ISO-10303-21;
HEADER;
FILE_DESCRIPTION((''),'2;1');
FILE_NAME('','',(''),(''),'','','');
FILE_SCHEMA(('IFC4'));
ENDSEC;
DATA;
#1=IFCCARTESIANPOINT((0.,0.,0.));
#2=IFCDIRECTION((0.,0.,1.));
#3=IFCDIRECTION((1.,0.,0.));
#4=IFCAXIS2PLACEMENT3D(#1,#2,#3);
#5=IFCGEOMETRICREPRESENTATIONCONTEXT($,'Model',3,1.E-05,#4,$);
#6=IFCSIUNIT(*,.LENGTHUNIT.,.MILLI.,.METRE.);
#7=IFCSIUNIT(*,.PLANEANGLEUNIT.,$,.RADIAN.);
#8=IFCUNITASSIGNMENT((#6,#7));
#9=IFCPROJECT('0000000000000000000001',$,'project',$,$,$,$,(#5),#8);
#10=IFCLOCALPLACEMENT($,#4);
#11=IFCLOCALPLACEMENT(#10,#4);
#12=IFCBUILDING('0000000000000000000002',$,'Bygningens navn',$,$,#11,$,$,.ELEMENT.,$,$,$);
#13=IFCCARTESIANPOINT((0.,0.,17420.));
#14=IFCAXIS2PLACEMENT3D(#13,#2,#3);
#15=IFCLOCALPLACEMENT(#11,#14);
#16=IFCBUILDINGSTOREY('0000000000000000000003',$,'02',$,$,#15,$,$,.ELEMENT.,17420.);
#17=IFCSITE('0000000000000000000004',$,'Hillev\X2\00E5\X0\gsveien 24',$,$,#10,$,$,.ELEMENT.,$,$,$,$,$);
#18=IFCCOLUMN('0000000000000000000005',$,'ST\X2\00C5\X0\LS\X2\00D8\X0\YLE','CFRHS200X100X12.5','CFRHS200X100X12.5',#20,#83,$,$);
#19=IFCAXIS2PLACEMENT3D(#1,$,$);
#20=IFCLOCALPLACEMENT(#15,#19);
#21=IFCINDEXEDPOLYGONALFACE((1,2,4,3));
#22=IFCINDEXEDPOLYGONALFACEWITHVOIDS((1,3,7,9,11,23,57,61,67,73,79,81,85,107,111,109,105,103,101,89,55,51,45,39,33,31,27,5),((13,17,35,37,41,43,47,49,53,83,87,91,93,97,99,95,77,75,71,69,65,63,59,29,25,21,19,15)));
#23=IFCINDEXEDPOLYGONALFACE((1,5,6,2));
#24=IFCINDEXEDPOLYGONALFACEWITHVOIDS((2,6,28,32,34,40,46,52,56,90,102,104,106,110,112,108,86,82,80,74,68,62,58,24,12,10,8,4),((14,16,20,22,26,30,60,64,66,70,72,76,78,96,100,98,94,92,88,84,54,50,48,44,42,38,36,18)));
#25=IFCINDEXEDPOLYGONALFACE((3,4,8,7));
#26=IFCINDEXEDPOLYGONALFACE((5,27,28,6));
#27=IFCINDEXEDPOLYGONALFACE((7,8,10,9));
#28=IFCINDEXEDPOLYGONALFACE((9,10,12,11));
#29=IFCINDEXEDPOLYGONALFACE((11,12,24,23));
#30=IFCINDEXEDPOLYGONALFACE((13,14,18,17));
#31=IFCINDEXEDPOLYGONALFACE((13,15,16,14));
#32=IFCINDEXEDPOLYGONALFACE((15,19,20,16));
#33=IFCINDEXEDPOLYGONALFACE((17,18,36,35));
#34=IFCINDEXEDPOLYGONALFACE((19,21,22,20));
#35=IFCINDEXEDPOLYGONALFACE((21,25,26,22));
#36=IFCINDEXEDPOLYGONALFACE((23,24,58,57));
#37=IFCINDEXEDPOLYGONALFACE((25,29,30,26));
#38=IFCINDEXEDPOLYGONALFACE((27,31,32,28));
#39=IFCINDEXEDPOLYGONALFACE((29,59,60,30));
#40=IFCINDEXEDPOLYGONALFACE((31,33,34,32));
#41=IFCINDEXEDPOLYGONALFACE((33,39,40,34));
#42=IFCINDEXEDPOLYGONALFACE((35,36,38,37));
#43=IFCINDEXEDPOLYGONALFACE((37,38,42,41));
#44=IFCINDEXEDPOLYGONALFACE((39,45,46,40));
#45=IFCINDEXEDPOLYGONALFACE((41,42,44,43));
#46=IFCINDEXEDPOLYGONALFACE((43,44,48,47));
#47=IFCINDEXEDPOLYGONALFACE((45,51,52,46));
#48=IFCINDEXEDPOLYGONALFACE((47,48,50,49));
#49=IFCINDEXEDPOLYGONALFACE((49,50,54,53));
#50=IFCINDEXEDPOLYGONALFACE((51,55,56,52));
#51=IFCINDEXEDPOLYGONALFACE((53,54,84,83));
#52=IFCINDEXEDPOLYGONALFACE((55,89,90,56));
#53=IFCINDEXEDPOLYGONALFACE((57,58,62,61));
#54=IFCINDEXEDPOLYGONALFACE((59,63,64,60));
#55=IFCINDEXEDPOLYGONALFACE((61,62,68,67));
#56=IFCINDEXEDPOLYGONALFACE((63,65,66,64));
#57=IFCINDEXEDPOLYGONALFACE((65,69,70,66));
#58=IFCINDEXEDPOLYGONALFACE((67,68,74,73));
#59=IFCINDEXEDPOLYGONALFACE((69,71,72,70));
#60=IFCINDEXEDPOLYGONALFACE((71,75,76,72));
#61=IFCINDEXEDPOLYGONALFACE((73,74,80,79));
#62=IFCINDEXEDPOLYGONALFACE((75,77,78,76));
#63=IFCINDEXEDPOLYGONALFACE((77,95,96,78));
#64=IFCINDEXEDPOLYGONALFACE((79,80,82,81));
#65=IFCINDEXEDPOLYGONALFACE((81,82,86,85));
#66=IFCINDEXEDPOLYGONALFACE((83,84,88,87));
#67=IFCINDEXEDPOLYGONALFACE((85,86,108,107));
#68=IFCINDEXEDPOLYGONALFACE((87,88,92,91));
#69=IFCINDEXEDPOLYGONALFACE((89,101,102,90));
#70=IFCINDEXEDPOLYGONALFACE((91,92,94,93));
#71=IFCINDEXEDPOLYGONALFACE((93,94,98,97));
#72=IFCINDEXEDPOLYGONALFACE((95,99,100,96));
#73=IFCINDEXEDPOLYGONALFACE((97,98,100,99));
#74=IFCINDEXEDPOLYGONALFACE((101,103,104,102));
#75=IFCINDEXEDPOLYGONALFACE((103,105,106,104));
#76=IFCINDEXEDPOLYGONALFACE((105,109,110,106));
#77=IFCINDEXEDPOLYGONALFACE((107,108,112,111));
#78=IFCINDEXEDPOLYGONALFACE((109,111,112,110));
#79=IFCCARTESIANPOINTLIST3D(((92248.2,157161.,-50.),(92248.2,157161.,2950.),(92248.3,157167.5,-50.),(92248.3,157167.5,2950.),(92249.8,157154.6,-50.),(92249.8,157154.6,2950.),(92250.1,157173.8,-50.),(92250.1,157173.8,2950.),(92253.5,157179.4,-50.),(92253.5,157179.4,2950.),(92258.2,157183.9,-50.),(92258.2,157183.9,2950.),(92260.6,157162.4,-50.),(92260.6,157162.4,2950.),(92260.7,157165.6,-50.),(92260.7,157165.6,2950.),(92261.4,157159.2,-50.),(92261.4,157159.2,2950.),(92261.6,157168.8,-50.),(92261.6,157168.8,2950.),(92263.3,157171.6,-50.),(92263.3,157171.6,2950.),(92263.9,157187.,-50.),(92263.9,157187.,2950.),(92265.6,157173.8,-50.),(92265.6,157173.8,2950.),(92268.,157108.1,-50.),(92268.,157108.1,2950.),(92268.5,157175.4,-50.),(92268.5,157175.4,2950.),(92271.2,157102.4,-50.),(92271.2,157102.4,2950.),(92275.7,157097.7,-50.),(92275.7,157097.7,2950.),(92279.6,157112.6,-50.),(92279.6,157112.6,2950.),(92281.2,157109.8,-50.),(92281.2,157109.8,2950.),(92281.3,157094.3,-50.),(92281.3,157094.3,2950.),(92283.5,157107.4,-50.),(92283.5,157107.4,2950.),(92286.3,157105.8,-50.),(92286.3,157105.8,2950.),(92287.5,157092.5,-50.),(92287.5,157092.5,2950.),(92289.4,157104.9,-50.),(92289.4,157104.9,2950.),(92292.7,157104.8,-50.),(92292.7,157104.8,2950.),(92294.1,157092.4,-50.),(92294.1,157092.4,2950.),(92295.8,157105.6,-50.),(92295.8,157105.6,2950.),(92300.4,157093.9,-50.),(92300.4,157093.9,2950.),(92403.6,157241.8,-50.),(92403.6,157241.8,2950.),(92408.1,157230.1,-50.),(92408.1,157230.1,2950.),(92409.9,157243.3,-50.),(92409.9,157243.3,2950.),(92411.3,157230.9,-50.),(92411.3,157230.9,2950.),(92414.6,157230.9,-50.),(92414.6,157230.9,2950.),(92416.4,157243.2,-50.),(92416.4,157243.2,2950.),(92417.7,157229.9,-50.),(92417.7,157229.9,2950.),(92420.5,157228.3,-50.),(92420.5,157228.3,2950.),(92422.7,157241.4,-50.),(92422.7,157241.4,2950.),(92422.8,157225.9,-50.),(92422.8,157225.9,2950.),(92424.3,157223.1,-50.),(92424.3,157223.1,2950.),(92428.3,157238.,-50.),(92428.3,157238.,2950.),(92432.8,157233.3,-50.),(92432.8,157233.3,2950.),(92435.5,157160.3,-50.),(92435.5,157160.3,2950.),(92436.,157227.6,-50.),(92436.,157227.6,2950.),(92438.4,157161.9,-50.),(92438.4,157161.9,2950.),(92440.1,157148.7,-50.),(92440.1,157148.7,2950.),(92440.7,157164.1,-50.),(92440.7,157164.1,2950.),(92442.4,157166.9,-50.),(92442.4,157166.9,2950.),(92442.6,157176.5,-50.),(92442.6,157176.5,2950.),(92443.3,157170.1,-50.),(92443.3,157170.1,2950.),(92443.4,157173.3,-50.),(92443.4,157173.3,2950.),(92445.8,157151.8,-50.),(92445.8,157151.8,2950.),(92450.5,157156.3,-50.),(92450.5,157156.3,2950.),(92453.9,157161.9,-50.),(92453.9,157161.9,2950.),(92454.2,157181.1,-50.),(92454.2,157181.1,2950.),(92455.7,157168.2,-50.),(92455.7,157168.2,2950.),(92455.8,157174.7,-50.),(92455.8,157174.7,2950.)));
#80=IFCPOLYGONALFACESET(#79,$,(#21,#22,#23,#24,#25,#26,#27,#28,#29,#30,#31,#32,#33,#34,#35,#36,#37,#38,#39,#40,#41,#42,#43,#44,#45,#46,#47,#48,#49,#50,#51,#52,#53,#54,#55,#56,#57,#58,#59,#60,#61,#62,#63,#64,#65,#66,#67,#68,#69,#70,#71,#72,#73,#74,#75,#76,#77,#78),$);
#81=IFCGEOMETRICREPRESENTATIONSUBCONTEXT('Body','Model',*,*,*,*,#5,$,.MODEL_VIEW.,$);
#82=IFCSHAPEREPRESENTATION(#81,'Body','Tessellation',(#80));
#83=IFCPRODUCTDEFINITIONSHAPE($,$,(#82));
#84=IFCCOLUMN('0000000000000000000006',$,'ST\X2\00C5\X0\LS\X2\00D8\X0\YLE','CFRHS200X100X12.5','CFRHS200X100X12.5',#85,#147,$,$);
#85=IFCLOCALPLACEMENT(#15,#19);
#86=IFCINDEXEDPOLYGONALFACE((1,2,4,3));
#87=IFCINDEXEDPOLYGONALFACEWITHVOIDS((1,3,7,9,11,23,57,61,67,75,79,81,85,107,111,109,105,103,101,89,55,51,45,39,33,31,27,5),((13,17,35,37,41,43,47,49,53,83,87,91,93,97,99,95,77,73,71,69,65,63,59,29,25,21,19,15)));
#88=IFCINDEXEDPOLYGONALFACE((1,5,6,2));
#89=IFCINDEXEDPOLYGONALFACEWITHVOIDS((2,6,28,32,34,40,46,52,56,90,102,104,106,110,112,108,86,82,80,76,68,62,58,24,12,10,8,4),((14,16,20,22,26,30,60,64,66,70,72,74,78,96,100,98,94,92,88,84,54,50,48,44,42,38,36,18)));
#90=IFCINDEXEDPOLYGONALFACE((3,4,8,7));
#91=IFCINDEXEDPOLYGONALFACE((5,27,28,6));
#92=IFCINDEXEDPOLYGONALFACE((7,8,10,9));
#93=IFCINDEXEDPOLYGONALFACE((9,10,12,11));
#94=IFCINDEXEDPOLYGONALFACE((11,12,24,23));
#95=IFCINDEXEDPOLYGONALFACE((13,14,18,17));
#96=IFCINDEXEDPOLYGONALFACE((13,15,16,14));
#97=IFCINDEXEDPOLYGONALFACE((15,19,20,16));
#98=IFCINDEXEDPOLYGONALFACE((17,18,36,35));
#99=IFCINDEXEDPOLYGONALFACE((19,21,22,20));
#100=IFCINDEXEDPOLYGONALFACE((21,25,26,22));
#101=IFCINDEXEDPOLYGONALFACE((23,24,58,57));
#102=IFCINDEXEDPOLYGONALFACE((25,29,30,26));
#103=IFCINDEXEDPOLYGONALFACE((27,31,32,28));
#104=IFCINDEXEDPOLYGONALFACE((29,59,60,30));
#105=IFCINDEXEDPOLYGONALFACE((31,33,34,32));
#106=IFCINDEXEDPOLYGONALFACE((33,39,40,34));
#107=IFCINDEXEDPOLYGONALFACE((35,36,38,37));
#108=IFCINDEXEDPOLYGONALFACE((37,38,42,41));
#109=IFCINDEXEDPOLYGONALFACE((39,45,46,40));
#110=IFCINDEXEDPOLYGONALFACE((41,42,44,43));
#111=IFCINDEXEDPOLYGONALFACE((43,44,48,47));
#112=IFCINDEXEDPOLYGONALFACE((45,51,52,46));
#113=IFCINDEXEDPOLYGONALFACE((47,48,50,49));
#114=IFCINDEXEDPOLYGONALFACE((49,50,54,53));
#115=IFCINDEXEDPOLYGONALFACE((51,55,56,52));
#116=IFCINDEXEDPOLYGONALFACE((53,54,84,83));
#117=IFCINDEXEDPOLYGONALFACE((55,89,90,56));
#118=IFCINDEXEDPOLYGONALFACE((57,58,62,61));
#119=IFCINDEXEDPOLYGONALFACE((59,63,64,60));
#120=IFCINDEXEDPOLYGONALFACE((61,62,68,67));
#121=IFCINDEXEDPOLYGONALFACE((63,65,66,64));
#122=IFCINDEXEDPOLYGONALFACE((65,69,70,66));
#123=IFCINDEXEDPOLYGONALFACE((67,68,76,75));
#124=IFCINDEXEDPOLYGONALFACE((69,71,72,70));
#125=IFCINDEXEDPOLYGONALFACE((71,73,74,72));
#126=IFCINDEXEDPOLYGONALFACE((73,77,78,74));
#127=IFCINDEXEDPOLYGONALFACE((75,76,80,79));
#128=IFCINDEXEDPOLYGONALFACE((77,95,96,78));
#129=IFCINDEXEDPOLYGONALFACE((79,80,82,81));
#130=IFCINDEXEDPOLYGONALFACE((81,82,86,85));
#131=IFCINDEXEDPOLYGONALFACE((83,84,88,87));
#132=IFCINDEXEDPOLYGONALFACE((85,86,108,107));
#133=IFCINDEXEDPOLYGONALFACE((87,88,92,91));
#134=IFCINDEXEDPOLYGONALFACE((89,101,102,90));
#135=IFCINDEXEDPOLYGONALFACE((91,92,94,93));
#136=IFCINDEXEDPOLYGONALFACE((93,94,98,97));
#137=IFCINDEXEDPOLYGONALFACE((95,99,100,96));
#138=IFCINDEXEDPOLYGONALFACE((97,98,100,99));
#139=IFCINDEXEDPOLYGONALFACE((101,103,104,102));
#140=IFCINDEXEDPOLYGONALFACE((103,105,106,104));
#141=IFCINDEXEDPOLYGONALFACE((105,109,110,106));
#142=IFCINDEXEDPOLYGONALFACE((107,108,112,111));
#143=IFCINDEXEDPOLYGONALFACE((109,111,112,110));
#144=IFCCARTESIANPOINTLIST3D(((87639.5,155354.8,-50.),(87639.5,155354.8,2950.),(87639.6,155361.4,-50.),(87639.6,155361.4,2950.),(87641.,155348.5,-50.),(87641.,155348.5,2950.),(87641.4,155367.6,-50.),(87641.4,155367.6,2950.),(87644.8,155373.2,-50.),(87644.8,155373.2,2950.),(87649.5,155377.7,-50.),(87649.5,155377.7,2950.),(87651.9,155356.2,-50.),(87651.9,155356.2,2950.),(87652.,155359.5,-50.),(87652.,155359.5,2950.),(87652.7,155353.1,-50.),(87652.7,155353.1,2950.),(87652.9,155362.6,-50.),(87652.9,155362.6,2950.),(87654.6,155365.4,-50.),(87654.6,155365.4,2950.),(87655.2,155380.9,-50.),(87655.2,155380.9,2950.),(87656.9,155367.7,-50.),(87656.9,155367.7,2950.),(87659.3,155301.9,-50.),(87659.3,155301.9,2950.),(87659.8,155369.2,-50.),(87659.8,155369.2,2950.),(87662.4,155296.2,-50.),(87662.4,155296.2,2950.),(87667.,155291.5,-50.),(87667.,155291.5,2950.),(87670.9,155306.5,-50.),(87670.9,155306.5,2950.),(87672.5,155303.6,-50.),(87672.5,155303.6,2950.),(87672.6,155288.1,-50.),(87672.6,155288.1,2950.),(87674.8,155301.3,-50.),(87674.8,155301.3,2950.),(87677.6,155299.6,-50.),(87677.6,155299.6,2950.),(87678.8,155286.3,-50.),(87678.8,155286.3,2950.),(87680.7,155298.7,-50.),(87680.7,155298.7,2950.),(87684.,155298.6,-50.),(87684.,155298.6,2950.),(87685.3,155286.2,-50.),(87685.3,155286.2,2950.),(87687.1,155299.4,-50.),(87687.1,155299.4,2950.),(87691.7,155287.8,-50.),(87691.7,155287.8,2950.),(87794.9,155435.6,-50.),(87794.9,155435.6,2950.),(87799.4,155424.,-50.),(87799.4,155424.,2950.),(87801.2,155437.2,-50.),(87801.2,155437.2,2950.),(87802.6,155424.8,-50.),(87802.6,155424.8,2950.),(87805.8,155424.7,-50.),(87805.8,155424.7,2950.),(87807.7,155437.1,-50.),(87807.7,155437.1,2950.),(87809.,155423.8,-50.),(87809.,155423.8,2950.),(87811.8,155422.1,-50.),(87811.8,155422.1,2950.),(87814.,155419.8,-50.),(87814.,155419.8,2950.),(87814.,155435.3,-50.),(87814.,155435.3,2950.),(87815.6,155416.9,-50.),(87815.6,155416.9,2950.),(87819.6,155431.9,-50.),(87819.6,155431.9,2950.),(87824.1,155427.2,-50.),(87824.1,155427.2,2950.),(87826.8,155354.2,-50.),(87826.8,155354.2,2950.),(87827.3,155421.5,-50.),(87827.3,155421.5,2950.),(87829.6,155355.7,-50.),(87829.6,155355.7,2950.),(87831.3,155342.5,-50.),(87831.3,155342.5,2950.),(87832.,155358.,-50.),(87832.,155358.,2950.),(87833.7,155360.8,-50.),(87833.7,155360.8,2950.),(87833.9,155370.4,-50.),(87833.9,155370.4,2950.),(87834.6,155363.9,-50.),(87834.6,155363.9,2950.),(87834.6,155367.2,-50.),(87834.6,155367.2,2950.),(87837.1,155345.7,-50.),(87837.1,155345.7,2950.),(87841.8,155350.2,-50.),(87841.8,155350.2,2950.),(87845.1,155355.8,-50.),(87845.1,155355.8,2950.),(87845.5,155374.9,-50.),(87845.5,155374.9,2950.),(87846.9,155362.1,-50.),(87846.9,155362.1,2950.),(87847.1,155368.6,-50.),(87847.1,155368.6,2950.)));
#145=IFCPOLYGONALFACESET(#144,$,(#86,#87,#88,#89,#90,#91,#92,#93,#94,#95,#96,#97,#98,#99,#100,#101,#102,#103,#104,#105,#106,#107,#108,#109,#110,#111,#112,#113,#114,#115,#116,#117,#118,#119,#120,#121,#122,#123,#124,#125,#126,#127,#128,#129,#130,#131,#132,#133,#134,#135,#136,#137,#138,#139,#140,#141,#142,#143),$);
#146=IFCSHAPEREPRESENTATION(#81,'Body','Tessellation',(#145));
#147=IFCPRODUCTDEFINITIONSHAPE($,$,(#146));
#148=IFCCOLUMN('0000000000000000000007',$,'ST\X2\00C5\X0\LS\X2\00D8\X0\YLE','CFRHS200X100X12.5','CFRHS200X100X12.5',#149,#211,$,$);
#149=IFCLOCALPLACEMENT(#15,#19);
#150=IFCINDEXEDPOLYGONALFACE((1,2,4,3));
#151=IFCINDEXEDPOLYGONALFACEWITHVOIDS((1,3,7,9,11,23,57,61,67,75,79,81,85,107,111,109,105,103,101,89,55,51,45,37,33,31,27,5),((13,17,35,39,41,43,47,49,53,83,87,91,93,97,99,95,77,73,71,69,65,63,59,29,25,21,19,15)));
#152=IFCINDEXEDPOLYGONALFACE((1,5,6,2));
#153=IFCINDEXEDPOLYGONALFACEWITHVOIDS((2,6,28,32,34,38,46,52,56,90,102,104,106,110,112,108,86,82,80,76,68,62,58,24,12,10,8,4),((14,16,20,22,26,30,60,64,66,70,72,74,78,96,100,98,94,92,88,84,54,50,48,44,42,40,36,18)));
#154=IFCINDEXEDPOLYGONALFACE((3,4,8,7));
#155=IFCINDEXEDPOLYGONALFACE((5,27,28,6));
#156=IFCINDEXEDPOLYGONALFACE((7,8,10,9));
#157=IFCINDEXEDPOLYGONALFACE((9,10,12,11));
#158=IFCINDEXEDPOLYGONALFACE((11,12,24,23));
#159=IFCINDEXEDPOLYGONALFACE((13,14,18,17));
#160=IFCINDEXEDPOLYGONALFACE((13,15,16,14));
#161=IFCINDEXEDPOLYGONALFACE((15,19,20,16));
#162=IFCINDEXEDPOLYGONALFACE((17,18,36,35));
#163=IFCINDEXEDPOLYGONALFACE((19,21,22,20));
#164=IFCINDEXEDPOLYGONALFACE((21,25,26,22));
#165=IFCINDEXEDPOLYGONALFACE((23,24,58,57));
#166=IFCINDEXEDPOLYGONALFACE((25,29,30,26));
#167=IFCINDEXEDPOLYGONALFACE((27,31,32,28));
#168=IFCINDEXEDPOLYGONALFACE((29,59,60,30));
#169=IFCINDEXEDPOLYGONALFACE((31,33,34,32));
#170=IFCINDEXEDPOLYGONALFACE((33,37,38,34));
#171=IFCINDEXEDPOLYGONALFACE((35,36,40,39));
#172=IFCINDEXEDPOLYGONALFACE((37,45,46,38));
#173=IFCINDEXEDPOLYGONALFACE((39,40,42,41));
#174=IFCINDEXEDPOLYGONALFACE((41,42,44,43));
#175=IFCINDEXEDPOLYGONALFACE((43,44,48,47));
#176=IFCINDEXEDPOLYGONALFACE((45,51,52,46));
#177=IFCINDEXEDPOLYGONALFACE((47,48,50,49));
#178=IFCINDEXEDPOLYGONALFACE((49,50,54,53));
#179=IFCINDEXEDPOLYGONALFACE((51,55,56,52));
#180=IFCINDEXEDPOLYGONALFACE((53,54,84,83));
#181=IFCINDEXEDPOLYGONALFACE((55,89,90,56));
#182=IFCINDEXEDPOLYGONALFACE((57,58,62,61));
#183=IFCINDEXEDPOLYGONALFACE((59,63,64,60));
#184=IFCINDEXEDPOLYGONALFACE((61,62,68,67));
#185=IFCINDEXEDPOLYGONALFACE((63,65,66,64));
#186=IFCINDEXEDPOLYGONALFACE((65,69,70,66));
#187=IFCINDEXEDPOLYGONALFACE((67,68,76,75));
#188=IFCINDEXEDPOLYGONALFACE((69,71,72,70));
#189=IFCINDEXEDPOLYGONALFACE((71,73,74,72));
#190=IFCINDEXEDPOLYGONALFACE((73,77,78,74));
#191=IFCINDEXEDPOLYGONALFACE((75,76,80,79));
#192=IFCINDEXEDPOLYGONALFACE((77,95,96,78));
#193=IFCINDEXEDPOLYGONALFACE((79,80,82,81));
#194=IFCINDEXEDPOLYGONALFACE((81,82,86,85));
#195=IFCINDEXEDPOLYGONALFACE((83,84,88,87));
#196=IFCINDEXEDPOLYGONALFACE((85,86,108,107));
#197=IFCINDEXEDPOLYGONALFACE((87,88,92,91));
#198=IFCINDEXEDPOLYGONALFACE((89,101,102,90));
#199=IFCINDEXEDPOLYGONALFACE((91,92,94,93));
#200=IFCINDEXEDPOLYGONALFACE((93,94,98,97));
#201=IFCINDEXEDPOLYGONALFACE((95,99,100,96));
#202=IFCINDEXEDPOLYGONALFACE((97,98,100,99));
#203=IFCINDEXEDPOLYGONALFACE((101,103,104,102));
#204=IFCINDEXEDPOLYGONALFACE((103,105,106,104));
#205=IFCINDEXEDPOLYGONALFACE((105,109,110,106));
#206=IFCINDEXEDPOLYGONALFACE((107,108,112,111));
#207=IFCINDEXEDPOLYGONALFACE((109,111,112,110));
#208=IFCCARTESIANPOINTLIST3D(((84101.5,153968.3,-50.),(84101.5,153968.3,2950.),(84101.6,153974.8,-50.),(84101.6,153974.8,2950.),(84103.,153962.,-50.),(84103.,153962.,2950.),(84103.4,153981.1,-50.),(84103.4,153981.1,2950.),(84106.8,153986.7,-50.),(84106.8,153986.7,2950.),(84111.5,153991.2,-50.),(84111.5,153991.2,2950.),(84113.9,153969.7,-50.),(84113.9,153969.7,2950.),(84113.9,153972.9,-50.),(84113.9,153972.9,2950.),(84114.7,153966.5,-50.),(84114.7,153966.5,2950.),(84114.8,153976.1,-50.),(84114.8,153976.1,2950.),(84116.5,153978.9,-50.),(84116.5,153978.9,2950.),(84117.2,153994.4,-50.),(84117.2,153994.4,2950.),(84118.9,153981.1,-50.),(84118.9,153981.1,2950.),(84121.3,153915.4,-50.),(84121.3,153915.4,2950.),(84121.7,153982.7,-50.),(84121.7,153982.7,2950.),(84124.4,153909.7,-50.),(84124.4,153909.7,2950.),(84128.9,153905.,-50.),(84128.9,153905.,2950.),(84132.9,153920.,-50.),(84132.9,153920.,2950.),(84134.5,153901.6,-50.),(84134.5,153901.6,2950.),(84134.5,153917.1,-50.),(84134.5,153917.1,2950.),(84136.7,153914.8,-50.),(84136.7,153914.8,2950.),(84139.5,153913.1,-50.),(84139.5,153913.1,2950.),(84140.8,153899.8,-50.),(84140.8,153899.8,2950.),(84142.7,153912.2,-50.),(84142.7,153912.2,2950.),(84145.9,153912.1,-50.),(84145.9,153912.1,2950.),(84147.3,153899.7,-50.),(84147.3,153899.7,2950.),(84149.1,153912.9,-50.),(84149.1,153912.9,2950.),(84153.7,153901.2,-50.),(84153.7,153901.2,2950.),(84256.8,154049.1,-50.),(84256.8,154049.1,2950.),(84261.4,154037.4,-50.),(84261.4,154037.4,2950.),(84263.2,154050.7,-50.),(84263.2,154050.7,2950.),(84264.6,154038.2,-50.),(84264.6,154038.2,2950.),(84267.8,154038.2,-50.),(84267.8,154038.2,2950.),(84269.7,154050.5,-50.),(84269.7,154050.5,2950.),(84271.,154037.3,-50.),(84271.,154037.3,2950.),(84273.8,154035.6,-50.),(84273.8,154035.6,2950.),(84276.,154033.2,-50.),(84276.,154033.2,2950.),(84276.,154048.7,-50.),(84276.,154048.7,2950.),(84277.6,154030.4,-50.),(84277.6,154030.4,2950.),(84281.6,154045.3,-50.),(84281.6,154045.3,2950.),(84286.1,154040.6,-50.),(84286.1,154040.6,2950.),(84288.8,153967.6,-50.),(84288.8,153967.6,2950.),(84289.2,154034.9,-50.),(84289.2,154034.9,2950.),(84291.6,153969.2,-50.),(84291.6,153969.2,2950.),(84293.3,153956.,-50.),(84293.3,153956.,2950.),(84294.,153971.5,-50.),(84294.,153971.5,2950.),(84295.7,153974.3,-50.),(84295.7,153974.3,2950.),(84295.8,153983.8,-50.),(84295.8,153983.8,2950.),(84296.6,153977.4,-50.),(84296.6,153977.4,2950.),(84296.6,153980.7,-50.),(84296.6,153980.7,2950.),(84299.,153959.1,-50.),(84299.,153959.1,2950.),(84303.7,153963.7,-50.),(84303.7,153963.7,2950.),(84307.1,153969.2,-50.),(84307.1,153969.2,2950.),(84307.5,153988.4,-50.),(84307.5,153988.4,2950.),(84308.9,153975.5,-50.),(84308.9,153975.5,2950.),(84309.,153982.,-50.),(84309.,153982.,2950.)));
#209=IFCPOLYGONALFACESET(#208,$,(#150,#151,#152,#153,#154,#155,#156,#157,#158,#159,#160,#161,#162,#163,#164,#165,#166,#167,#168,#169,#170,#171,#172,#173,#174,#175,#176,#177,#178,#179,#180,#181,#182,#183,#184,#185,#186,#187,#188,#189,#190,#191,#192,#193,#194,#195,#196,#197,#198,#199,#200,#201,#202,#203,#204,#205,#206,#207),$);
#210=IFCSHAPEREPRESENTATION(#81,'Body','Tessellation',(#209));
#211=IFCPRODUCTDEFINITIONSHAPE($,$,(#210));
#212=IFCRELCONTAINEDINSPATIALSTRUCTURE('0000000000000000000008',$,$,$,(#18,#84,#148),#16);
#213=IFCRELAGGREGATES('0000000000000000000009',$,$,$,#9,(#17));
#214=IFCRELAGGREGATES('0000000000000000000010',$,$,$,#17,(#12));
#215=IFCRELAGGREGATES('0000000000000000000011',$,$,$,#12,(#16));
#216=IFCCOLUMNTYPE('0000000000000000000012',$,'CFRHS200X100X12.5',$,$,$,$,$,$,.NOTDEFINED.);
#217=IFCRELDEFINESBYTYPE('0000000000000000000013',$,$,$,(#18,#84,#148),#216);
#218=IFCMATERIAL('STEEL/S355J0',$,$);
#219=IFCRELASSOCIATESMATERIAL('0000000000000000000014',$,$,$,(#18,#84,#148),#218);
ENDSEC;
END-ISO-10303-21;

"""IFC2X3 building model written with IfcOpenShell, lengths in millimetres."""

from ifc_helpers import new_model, si_unit, frame, frame_2d, origin_with_axes, place, context, subcontext, project, spatial, hollow_rectangle, extrude, material, type_object, element, save


model = new_model("IFC2X3")

# Units and contexts
model_context = context("Model", 3, precision=1e-05, world=origin_with_axes())
body_context = subcontext(model_context, "Body", "Model", "MODEL_VIEW")
ifc_project = project(units=[si_unit("LENGTHUNIT", "METRE", prefix="MILLI"), si_unit("PLANEANGLEUNIT", "RADIAN")], contexts=[model_context])

# Site, building, storey
site_placement = place(None, origin_with_axes())
site = spatial("IfcSite", under=ifc_project, at=site_placement, Name="Hillevågsveien 24", CompositionType="ELEMENT")
building_placement = place(site_placement, origin_with_axes())
building = spatial("IfcBuilding", under=site, at=building_placement, Name="Bygningens navn", CompositionType="ELEMENT")
storey_placement = place(building_placement, frame((0.0, 0.0, 17420.0), z_axis=(0.0, 0.0, 1.0), x_axis=(1.0, 0.0, 0.0)))
storey = spatial("IfcBuildingStorey", under=building, at=storey_placement, Name="02", CompositionType="ELEMENT", Elevation=17420.0)

# Columns
ifc_material_1 = material(Name="STEEL/S355J0")
column_type_1 = type_object("IfcColumnType", Name="CFRHS200X100X12.5", PredefinedType="NOTDEFINED")
for number, where, z_axis, x_axis, name in (
    (1, (92352.0, 157167.9, -50.0), (0.0, 0.0, 1.0), (0.931056, 0.364877, 0.0), "STÅLSØYLE"),
    (2, (87743.3, 155361.7, -50.0), (0.0, 0.0, 1.0), (0.931056, 0.364877, 0.0), "STÅLSØYLE"),
    (3, (84205.3, 153975.2, -50.0), (0.0, 0.0, 1.0), (0.931056, 0.364877, 0.0), "STÅLSØYLE"),
):
    element("IfcColumn", number, at=place(storey_placement, frame(where, z_axis=z_axis, x_axis=x_axis)), inside=storey, type_object=column_type_1, material=ifc_material_1, Name=name, Description="CFRHS200X100X12.5", ObjectType="CFRHS200X100X12.5", context=body_context, shape_type="SweptSolid", body=[
        extrude(hollow_rectangle(XDim=100.0, YDim=200.0, WallThickness=12.5, InnerFilletRadius=12.5, OuterFilletRadius=25.0, at=frame_2d((0.0, 0.0), x_axis=(1.0, 0.0))), frame((0.0, 0.0, 3000.0), z_axis=(0.0, 0.0, -1.0), x_axis=(0.0, 1.0, 0.0)), (0.0, 0.0, 1.0), 3000.0),
    ])

save(model, "model.ifc")
